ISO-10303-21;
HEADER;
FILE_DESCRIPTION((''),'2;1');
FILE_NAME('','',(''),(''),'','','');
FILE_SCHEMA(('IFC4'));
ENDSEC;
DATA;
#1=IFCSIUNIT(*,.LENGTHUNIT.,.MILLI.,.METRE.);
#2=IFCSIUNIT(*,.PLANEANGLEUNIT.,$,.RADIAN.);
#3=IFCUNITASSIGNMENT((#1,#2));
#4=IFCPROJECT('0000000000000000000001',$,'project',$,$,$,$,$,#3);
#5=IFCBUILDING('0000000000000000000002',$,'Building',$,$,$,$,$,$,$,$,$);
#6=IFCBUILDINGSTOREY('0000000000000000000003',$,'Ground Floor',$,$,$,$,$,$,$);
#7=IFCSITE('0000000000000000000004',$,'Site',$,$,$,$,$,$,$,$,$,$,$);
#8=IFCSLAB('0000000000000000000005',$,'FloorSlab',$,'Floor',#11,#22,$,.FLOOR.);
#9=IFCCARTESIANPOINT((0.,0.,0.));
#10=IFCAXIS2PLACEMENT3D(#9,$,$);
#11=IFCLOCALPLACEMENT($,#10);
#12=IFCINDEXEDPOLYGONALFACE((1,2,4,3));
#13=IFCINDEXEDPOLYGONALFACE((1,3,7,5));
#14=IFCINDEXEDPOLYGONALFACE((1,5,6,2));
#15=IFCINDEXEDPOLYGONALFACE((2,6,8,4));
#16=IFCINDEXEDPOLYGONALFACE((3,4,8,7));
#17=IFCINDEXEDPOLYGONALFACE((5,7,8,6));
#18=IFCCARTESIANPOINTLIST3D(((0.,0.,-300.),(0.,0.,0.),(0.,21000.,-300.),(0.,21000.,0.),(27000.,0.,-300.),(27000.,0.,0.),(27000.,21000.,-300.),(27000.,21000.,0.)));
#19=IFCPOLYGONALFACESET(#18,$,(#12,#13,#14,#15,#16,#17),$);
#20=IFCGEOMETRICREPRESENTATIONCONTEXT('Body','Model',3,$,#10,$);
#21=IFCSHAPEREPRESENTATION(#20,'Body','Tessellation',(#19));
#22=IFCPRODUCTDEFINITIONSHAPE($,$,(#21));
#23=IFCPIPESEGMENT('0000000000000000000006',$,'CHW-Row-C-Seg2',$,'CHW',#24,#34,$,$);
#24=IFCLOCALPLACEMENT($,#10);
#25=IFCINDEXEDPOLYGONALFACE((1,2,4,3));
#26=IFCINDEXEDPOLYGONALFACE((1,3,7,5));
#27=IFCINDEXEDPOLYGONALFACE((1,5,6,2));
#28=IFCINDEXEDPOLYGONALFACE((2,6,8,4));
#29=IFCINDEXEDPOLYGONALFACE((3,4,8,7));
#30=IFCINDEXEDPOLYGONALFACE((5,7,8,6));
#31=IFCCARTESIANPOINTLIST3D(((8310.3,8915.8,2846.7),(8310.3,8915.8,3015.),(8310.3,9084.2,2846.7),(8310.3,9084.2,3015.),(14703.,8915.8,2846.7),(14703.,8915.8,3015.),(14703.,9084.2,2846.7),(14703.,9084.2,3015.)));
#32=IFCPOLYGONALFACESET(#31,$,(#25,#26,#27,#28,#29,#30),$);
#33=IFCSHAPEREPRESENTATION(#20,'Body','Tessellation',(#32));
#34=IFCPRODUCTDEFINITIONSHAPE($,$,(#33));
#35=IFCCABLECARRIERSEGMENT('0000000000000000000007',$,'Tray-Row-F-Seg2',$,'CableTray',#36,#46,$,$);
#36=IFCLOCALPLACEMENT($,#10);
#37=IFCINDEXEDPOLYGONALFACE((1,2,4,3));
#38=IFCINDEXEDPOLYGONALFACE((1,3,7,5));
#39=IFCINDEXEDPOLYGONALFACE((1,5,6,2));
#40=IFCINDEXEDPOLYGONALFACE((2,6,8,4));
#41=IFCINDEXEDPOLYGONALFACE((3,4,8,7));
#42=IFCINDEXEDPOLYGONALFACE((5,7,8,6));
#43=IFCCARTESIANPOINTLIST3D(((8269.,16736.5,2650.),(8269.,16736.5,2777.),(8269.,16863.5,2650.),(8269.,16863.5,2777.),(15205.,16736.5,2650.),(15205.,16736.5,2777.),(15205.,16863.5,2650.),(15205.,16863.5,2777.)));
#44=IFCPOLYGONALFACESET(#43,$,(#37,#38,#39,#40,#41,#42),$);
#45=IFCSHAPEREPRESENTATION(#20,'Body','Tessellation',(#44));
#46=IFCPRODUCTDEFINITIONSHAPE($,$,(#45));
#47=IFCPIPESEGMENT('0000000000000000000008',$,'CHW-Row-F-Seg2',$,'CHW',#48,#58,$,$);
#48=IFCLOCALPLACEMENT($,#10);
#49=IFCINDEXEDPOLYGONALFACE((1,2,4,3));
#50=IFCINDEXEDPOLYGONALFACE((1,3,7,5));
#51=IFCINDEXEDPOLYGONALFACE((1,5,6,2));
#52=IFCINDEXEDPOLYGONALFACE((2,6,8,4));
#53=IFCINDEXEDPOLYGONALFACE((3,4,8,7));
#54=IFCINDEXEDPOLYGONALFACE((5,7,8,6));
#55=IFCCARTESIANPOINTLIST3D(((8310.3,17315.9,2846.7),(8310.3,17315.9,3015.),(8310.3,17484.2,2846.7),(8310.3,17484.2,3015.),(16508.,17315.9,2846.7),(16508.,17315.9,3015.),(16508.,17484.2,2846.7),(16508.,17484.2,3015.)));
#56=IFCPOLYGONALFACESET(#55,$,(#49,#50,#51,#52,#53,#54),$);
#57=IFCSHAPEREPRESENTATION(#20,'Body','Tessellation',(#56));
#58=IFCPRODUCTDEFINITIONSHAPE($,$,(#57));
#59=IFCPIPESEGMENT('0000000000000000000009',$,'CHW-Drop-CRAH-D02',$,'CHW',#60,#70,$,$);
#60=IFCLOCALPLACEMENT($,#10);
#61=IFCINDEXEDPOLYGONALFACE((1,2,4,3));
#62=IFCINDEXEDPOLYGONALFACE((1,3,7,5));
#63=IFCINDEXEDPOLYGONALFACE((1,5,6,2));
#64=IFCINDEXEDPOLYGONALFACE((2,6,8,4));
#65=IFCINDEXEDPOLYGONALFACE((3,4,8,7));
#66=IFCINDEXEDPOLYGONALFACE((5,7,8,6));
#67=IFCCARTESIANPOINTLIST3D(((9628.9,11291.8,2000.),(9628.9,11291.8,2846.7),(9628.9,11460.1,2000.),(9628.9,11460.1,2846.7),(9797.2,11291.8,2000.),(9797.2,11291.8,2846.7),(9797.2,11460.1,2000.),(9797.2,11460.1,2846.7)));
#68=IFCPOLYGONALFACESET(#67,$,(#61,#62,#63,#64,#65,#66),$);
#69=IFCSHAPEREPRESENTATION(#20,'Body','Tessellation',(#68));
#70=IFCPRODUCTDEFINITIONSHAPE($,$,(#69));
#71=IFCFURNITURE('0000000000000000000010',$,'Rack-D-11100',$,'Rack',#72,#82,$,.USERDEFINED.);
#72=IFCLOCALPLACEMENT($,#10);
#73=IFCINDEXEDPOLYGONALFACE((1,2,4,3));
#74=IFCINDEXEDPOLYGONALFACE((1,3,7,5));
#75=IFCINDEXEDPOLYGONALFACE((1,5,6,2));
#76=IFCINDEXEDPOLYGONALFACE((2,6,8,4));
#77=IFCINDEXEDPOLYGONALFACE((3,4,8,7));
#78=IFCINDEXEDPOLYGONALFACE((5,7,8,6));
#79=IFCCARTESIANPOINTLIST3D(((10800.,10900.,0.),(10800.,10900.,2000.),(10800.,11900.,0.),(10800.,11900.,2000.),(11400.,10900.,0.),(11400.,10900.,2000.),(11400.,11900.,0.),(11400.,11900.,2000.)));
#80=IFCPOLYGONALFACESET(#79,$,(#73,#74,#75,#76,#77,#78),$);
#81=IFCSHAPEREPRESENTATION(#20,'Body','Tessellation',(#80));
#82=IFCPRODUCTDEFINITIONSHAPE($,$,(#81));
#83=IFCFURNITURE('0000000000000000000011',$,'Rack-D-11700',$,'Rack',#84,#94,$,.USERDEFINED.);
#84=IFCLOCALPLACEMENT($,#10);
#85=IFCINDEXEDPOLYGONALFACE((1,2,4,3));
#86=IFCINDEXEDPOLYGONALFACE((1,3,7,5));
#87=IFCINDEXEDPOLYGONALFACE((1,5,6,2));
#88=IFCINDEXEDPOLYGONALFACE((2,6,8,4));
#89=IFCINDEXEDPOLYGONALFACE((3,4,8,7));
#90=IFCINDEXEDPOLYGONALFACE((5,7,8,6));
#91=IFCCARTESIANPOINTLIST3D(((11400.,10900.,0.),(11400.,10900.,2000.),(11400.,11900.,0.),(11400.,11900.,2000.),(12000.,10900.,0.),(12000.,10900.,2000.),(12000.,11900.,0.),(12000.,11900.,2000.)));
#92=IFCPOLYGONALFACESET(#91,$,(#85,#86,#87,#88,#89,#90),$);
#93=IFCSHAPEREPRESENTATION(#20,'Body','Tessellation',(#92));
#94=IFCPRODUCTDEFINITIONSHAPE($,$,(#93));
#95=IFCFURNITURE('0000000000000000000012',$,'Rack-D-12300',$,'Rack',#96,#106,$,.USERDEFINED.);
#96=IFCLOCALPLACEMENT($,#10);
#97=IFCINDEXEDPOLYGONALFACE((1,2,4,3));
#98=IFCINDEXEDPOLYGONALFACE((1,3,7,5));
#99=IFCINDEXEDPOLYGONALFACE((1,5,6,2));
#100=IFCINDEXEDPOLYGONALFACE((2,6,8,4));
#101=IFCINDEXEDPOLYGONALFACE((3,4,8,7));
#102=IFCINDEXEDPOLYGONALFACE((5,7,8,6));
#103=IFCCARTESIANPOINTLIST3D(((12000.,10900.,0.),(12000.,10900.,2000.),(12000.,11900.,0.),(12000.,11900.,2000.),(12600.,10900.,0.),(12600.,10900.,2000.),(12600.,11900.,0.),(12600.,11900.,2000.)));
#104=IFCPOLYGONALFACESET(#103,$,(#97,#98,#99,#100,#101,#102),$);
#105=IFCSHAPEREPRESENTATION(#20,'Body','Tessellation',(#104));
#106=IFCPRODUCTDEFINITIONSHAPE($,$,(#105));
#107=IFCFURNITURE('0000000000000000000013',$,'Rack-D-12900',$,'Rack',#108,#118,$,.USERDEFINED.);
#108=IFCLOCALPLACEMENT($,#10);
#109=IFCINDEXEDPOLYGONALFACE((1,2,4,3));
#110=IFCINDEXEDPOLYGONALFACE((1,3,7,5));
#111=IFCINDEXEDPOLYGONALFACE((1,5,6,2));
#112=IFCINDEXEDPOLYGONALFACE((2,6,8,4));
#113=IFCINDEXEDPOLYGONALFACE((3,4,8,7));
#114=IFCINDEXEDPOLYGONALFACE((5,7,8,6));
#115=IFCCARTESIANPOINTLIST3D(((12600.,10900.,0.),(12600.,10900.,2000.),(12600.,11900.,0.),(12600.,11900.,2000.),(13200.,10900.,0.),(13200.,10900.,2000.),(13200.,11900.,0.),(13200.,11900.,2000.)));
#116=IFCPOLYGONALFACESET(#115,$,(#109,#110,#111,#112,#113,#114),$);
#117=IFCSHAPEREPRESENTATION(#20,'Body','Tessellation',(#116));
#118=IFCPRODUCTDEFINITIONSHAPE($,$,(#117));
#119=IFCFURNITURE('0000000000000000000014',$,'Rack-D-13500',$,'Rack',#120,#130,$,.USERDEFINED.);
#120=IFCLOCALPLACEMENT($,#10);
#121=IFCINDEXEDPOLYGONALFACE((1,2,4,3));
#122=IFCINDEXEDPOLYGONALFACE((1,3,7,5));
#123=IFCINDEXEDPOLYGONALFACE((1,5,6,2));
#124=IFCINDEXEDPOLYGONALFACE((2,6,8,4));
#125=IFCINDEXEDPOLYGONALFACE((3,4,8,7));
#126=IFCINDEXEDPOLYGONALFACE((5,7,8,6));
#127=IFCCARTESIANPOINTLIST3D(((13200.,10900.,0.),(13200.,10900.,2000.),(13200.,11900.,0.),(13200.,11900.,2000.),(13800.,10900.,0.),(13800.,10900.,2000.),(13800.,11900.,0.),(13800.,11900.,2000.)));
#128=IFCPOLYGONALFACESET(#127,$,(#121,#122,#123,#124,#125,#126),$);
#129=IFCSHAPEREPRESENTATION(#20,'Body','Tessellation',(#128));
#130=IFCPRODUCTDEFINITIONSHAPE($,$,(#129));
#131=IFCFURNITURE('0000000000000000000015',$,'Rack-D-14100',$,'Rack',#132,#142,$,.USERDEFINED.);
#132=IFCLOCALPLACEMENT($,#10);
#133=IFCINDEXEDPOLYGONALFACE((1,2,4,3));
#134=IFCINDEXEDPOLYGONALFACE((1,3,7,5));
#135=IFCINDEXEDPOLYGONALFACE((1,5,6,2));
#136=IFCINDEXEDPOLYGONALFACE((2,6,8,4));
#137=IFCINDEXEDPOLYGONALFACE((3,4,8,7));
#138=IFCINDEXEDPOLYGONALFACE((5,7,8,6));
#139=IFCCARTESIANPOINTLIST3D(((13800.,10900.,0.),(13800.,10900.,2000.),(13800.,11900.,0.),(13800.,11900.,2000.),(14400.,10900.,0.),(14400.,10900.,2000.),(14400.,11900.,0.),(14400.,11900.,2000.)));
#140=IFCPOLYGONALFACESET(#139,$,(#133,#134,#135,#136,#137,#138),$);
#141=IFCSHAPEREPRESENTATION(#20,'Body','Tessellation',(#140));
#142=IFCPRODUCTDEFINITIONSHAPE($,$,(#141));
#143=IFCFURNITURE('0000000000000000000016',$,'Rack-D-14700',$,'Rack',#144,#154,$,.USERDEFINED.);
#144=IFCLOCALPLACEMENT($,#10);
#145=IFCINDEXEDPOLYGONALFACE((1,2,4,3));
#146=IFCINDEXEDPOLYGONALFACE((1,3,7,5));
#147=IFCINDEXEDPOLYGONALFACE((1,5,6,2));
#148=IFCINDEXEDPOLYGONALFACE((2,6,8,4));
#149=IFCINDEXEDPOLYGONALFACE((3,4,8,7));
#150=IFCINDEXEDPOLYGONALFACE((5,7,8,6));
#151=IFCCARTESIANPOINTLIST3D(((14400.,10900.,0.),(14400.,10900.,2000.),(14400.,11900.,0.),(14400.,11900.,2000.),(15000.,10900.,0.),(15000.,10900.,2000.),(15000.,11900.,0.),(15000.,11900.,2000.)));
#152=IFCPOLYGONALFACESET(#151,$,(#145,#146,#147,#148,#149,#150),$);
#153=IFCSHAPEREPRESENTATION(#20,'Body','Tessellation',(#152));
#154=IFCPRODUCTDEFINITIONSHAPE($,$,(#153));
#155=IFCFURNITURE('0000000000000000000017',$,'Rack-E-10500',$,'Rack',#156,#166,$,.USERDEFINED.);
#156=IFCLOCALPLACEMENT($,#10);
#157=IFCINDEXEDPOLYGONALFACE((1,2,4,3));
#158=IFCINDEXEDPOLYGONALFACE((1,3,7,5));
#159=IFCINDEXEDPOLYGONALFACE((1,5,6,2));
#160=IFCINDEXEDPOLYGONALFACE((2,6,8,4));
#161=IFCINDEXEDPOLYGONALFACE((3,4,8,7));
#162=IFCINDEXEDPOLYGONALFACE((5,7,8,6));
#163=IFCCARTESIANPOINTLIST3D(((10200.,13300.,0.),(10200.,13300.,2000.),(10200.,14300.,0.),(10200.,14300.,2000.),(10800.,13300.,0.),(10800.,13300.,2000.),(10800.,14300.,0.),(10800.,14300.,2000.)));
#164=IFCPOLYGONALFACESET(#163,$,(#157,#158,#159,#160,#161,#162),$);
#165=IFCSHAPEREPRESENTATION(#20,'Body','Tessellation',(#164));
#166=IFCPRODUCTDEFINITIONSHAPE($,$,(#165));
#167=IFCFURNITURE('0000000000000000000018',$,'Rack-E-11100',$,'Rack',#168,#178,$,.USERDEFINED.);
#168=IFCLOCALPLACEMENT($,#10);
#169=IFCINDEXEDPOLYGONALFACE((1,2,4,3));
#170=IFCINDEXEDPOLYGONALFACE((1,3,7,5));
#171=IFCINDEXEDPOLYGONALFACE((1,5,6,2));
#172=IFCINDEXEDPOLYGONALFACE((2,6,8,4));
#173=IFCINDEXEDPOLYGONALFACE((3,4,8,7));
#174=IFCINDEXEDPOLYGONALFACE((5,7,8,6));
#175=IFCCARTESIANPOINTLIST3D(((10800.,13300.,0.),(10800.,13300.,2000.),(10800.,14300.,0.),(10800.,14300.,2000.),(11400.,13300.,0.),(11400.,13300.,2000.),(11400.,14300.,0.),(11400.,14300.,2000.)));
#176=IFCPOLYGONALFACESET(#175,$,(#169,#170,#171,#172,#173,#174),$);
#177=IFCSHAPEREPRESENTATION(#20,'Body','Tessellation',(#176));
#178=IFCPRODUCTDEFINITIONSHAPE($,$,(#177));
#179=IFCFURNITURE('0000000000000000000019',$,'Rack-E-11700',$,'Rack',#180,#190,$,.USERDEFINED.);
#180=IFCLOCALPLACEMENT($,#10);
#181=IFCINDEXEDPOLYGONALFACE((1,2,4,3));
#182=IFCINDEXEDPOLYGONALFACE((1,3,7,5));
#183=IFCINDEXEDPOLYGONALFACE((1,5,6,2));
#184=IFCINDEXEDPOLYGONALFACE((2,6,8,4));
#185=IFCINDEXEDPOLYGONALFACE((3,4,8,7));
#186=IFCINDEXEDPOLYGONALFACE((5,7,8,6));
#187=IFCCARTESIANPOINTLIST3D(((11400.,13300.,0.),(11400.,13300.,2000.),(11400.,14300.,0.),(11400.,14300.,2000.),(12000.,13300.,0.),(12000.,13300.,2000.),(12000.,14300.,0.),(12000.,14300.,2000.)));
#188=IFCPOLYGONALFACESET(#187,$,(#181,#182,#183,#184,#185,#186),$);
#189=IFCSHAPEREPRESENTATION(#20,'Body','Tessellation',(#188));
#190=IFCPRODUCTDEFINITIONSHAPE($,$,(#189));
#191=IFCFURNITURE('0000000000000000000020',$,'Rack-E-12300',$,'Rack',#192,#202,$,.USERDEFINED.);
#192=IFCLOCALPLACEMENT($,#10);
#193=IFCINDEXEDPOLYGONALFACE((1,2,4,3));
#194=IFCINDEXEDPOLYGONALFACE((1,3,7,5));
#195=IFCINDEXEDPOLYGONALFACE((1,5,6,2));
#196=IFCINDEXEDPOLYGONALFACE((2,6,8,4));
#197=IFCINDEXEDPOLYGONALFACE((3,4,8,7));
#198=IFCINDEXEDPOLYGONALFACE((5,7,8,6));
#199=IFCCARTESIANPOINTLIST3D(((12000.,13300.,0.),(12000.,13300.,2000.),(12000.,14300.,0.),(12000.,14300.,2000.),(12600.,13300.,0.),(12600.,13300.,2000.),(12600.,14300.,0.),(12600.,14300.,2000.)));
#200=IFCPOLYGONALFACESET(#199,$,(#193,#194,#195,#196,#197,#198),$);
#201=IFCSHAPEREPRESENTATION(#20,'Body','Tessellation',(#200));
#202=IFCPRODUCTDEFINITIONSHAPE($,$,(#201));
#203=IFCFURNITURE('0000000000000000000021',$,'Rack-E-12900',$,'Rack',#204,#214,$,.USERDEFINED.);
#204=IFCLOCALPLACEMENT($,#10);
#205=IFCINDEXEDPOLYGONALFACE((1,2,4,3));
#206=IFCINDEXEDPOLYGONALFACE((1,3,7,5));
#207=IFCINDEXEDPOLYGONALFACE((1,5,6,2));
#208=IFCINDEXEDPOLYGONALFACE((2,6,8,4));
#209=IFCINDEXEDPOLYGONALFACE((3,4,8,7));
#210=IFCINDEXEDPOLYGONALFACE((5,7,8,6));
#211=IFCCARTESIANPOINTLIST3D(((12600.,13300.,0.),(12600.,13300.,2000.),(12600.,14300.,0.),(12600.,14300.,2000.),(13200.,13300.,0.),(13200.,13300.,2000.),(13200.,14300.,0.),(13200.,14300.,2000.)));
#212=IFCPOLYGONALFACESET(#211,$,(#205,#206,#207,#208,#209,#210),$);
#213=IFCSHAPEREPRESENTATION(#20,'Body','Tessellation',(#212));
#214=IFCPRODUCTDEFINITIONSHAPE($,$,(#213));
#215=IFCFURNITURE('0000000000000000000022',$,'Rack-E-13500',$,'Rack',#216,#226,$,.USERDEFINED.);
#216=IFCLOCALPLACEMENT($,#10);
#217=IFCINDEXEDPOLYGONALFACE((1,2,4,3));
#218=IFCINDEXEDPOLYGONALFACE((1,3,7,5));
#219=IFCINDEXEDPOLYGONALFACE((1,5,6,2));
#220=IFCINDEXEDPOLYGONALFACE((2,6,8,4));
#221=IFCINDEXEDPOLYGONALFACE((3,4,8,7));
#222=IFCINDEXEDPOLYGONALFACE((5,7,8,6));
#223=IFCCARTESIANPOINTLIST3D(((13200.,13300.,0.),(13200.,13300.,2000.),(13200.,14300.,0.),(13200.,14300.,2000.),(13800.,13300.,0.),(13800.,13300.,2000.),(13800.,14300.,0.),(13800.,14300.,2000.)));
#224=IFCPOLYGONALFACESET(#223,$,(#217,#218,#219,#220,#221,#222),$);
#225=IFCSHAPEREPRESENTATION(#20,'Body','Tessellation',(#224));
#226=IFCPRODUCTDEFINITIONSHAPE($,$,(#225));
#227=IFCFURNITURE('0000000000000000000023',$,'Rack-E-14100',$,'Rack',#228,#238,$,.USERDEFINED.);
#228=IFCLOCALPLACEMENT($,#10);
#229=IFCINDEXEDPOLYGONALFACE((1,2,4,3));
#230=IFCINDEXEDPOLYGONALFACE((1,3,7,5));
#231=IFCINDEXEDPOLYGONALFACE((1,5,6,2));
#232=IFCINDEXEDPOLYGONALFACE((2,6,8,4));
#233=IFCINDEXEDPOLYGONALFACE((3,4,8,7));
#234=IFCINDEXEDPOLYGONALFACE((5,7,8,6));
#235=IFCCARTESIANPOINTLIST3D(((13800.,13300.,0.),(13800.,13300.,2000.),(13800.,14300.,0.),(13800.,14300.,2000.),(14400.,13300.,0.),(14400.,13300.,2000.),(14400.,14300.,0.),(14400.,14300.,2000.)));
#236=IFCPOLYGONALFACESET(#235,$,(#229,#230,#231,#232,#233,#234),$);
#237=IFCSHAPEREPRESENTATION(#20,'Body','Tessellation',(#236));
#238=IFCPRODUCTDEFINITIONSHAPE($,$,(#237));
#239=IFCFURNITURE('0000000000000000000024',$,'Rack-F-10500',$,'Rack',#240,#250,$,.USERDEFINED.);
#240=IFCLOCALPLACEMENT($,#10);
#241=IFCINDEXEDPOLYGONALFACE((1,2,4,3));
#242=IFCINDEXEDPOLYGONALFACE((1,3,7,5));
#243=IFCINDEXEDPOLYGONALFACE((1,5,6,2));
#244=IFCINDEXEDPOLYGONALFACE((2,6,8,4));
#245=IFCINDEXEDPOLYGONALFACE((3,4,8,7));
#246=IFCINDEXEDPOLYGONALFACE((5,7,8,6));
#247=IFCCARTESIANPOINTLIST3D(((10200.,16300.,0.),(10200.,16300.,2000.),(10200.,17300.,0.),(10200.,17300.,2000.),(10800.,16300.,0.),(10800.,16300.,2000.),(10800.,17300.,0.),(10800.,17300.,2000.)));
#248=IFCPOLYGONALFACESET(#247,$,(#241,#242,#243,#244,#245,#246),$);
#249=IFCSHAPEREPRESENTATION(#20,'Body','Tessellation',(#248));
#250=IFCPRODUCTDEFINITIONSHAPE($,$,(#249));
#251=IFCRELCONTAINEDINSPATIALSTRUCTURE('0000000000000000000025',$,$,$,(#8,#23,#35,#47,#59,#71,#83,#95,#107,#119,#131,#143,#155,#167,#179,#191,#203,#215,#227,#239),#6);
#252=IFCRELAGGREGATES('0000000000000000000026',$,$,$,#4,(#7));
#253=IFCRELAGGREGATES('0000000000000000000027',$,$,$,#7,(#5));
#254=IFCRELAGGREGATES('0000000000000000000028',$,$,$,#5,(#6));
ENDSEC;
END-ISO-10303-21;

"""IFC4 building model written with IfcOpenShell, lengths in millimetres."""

from ifc_helpers import new_model, si_unit, frame, origin, place, context, project, spatial, rectangle, extrude, element, save


model = new_model("IFC4")

# Units and contexts
model_context = context("Model", 3, world=origin(), identifier="Body")
ifc_project = project(units=[si_unit("LENGTHUNIT", "METRE", prefix="MILLI"), si_unit("PLANEANGLEUNIT", "RADIAN")])

# Site, building, storey
site = spatial("IfcSite", under=ifc_project, Name="Site")
building = spatial("IfcBuilding", under=site, Name="Building")
storey = spatial("IfcBuildingStorey", under=building, Name="Ground Floor")

# Slab
slab_placement = place(None, frame((13500.0, 10500.0, -300.0), z_axis=(0.0, 0.0, 1.0), x_axis=(1.0, 0.0, 0.0)))
element("IfcSlab", 1, at=slab_placement, inside=storey, Name="FloorSlab", ObjectType="Floor", PredefinedType="FLOOR", context=model_context, shape_type="SweptSolid", body=[
    extrude(rectangle(XDim=27000.0, YDim=21000.0), origin(), (0.0, 0.0, 1.0), 300.0),
])

# Pipe segment
pipe_segment_1_placement = place(None, frame((11506.6, 9000.0, 2846.7), z_axis=(0.0, 0.0, 1.0), x_axis=(1.0, 0.0, 0.0)))
element("IfcPipeSegment", 2, at=pipe_segment_1_placement, inside=storey, Name="CHW-Row-C-Seg2", ObjectType="CHW", context=model_context, shape_type="SweptSolid", body=[
    extrude(rectangle(XDim=6392.7, YDim=168.3), origin(), (0.0, 0.0, 1.0), 168.3),
])

# Cable carrier segment
cable_carrier_segment_placement = place(None, frame((11737.0, 16800.0, 2650.0), z_axis=(0.0, 0.0, 1.0), x_axis=(1.0, 0.0, 0.0)))
element("IfcCableCarrierSegment", 3, at=cable_carrier_segment_placement, inside=storey, Name="Tray-Row-F-Seg2", ObjectType="CableTray", context=model_context, shape_type="SweptSolid", body=[
    extrude(rectangle(XDim=6936.0, YDim=127.0), origin(), (0.0, 0.0, 1.0), 127.0),
])

# Pipe segments
pipe_segment_2_placement = place(None, frame((12409.1, 17400.0, 2846.7), z_axis=(0.0, 0.0, 1.0), x_axis=(1.0, 0.0, 0.0)))
element("IfcPipeSegment", 4, at=pipe_segment_2_placement, inside=storey, Name="CHW-Row-F-Seg2", ObjectType="CHW", context=model_context, shape_type="SweptSolid", body=[
    extrude(rectangle(XDim=8197.7, YDim=168.3), origin(), (0.0, 0.0, 1.0), 168.3),
])
pipe_segment_3_placement = place(None, frame((9713.0, 11376.0, 2000.0), z_axis=(0.0, 0.0, 1.0), x_axis=(1.0, 0.0, 0.0)))
element("IfcPipeSegment", 5, at=pipe_segment_3_placement, inside=storey, Name="CHW-Drop-CRAH-D02", ObjectType="CHW", context=model_context, shape_type="SweptSolid", body=[
    extrude(rectangle(XDim=168.3, YDim=168.3), origin(), (0.0, 0.0, 1.0), 846.7),
])

# Furniture
for number, where, z_axis, x_axis, name in (
    (6, (11100.0, 11400.0, 0.0), (0.0, 0.0, 1.0), (1.0, 0.0, 0.0), "Rack-D-11100"),
    (7, (11700.0, 11400.0, 0.0), (0.0, 0.0, 1.0), (1.0, 0.0, 0.0), "Rack-D-11700"),
    (8, (12300.0, 11400.0, 0.0), (0.0, 0.0, 1.0), (1.0, 0.0, 0.0), "Rack-D-12300"),
    (9, (12900.0, 11400.0, 0.0), (0.0, 0.0, 1.0), (1.0, 0.0, 0.0), "Rack-D-12900"),
    (10, (13500.0, 11400.0, 0.0), (0.0, 0.0, 1.0), (1.0, 0.0, 0.0), "Rack-D-13500"),
    (11, (14100.0, 11400.0, 0.0), (0.0, 0.0, 1.0), (1.0, 0.0, 0.0), "Rack-D-14100"),
    (12, (14700.0, 11400.0, 0.0), (0.0, 0.0, 1.0), (1.0, 0.0, 0.0), "Rack-D-14700"),
    (13, (10500.0, 13800.0, 0.0), (0.0, 0.0, 1.0), (1.0, 0.0, 0.0), "Rack-E-10500"),
    (14, (11100.0, 13800.0, 0.0), (0.0, 0.0, 1.0), (1.0, 0.0, 0.0), "Rack-E-11100"),
    (15, (11700.0, 13800.0, 0.0), (0.0, 0.0, 1.0), (1.0, 0.0, 0.0), "Rack-E-11700"),
    (16, (12300.0, 13800.0, 0.0), (0.0, 0.0, 1.0), (1.0, 0.0, 0.0), "Rack-E-12300"),
    (17, (12900.0, 13800.0, 0.0), (0.0, 0.0, 1.0), (1.0, 0.0, 0.0), "Rack-E-12900"),
    (18, (13500.0, 13800.0, 0.0), (0.0, 0.0, 1.0), (1.0, 0.0, 0.0), "Rack-E-13500"),
    (19, (14100.0, 13800.0, 0.0), (0.0, 0.0, 1.0), (1.0, 0.0, 0.0), "Rack-E-14100"),
    (20, (10500.0, 16800.0, 0.0), (0.0, 0.0, 1.0), (1.0, 0.0, 0.0), "Rack-F-10500"),
):
    element("IfcFurniture", number, at=place(None, frame(where, z_axis=z_axis, x_axis=x_axis)), inside=storey, Name=name, ObjectType="Rack", PredefinedType="USERDEFINED", context=model_context, shape_type="SweptSolid", body=[
        extrude(rectangle(XDim=600.0, YDim=1000.0), origin(), (0.0, 0.0, 1.0), 2000.0),
    ])

save(model, "model.ifc")
